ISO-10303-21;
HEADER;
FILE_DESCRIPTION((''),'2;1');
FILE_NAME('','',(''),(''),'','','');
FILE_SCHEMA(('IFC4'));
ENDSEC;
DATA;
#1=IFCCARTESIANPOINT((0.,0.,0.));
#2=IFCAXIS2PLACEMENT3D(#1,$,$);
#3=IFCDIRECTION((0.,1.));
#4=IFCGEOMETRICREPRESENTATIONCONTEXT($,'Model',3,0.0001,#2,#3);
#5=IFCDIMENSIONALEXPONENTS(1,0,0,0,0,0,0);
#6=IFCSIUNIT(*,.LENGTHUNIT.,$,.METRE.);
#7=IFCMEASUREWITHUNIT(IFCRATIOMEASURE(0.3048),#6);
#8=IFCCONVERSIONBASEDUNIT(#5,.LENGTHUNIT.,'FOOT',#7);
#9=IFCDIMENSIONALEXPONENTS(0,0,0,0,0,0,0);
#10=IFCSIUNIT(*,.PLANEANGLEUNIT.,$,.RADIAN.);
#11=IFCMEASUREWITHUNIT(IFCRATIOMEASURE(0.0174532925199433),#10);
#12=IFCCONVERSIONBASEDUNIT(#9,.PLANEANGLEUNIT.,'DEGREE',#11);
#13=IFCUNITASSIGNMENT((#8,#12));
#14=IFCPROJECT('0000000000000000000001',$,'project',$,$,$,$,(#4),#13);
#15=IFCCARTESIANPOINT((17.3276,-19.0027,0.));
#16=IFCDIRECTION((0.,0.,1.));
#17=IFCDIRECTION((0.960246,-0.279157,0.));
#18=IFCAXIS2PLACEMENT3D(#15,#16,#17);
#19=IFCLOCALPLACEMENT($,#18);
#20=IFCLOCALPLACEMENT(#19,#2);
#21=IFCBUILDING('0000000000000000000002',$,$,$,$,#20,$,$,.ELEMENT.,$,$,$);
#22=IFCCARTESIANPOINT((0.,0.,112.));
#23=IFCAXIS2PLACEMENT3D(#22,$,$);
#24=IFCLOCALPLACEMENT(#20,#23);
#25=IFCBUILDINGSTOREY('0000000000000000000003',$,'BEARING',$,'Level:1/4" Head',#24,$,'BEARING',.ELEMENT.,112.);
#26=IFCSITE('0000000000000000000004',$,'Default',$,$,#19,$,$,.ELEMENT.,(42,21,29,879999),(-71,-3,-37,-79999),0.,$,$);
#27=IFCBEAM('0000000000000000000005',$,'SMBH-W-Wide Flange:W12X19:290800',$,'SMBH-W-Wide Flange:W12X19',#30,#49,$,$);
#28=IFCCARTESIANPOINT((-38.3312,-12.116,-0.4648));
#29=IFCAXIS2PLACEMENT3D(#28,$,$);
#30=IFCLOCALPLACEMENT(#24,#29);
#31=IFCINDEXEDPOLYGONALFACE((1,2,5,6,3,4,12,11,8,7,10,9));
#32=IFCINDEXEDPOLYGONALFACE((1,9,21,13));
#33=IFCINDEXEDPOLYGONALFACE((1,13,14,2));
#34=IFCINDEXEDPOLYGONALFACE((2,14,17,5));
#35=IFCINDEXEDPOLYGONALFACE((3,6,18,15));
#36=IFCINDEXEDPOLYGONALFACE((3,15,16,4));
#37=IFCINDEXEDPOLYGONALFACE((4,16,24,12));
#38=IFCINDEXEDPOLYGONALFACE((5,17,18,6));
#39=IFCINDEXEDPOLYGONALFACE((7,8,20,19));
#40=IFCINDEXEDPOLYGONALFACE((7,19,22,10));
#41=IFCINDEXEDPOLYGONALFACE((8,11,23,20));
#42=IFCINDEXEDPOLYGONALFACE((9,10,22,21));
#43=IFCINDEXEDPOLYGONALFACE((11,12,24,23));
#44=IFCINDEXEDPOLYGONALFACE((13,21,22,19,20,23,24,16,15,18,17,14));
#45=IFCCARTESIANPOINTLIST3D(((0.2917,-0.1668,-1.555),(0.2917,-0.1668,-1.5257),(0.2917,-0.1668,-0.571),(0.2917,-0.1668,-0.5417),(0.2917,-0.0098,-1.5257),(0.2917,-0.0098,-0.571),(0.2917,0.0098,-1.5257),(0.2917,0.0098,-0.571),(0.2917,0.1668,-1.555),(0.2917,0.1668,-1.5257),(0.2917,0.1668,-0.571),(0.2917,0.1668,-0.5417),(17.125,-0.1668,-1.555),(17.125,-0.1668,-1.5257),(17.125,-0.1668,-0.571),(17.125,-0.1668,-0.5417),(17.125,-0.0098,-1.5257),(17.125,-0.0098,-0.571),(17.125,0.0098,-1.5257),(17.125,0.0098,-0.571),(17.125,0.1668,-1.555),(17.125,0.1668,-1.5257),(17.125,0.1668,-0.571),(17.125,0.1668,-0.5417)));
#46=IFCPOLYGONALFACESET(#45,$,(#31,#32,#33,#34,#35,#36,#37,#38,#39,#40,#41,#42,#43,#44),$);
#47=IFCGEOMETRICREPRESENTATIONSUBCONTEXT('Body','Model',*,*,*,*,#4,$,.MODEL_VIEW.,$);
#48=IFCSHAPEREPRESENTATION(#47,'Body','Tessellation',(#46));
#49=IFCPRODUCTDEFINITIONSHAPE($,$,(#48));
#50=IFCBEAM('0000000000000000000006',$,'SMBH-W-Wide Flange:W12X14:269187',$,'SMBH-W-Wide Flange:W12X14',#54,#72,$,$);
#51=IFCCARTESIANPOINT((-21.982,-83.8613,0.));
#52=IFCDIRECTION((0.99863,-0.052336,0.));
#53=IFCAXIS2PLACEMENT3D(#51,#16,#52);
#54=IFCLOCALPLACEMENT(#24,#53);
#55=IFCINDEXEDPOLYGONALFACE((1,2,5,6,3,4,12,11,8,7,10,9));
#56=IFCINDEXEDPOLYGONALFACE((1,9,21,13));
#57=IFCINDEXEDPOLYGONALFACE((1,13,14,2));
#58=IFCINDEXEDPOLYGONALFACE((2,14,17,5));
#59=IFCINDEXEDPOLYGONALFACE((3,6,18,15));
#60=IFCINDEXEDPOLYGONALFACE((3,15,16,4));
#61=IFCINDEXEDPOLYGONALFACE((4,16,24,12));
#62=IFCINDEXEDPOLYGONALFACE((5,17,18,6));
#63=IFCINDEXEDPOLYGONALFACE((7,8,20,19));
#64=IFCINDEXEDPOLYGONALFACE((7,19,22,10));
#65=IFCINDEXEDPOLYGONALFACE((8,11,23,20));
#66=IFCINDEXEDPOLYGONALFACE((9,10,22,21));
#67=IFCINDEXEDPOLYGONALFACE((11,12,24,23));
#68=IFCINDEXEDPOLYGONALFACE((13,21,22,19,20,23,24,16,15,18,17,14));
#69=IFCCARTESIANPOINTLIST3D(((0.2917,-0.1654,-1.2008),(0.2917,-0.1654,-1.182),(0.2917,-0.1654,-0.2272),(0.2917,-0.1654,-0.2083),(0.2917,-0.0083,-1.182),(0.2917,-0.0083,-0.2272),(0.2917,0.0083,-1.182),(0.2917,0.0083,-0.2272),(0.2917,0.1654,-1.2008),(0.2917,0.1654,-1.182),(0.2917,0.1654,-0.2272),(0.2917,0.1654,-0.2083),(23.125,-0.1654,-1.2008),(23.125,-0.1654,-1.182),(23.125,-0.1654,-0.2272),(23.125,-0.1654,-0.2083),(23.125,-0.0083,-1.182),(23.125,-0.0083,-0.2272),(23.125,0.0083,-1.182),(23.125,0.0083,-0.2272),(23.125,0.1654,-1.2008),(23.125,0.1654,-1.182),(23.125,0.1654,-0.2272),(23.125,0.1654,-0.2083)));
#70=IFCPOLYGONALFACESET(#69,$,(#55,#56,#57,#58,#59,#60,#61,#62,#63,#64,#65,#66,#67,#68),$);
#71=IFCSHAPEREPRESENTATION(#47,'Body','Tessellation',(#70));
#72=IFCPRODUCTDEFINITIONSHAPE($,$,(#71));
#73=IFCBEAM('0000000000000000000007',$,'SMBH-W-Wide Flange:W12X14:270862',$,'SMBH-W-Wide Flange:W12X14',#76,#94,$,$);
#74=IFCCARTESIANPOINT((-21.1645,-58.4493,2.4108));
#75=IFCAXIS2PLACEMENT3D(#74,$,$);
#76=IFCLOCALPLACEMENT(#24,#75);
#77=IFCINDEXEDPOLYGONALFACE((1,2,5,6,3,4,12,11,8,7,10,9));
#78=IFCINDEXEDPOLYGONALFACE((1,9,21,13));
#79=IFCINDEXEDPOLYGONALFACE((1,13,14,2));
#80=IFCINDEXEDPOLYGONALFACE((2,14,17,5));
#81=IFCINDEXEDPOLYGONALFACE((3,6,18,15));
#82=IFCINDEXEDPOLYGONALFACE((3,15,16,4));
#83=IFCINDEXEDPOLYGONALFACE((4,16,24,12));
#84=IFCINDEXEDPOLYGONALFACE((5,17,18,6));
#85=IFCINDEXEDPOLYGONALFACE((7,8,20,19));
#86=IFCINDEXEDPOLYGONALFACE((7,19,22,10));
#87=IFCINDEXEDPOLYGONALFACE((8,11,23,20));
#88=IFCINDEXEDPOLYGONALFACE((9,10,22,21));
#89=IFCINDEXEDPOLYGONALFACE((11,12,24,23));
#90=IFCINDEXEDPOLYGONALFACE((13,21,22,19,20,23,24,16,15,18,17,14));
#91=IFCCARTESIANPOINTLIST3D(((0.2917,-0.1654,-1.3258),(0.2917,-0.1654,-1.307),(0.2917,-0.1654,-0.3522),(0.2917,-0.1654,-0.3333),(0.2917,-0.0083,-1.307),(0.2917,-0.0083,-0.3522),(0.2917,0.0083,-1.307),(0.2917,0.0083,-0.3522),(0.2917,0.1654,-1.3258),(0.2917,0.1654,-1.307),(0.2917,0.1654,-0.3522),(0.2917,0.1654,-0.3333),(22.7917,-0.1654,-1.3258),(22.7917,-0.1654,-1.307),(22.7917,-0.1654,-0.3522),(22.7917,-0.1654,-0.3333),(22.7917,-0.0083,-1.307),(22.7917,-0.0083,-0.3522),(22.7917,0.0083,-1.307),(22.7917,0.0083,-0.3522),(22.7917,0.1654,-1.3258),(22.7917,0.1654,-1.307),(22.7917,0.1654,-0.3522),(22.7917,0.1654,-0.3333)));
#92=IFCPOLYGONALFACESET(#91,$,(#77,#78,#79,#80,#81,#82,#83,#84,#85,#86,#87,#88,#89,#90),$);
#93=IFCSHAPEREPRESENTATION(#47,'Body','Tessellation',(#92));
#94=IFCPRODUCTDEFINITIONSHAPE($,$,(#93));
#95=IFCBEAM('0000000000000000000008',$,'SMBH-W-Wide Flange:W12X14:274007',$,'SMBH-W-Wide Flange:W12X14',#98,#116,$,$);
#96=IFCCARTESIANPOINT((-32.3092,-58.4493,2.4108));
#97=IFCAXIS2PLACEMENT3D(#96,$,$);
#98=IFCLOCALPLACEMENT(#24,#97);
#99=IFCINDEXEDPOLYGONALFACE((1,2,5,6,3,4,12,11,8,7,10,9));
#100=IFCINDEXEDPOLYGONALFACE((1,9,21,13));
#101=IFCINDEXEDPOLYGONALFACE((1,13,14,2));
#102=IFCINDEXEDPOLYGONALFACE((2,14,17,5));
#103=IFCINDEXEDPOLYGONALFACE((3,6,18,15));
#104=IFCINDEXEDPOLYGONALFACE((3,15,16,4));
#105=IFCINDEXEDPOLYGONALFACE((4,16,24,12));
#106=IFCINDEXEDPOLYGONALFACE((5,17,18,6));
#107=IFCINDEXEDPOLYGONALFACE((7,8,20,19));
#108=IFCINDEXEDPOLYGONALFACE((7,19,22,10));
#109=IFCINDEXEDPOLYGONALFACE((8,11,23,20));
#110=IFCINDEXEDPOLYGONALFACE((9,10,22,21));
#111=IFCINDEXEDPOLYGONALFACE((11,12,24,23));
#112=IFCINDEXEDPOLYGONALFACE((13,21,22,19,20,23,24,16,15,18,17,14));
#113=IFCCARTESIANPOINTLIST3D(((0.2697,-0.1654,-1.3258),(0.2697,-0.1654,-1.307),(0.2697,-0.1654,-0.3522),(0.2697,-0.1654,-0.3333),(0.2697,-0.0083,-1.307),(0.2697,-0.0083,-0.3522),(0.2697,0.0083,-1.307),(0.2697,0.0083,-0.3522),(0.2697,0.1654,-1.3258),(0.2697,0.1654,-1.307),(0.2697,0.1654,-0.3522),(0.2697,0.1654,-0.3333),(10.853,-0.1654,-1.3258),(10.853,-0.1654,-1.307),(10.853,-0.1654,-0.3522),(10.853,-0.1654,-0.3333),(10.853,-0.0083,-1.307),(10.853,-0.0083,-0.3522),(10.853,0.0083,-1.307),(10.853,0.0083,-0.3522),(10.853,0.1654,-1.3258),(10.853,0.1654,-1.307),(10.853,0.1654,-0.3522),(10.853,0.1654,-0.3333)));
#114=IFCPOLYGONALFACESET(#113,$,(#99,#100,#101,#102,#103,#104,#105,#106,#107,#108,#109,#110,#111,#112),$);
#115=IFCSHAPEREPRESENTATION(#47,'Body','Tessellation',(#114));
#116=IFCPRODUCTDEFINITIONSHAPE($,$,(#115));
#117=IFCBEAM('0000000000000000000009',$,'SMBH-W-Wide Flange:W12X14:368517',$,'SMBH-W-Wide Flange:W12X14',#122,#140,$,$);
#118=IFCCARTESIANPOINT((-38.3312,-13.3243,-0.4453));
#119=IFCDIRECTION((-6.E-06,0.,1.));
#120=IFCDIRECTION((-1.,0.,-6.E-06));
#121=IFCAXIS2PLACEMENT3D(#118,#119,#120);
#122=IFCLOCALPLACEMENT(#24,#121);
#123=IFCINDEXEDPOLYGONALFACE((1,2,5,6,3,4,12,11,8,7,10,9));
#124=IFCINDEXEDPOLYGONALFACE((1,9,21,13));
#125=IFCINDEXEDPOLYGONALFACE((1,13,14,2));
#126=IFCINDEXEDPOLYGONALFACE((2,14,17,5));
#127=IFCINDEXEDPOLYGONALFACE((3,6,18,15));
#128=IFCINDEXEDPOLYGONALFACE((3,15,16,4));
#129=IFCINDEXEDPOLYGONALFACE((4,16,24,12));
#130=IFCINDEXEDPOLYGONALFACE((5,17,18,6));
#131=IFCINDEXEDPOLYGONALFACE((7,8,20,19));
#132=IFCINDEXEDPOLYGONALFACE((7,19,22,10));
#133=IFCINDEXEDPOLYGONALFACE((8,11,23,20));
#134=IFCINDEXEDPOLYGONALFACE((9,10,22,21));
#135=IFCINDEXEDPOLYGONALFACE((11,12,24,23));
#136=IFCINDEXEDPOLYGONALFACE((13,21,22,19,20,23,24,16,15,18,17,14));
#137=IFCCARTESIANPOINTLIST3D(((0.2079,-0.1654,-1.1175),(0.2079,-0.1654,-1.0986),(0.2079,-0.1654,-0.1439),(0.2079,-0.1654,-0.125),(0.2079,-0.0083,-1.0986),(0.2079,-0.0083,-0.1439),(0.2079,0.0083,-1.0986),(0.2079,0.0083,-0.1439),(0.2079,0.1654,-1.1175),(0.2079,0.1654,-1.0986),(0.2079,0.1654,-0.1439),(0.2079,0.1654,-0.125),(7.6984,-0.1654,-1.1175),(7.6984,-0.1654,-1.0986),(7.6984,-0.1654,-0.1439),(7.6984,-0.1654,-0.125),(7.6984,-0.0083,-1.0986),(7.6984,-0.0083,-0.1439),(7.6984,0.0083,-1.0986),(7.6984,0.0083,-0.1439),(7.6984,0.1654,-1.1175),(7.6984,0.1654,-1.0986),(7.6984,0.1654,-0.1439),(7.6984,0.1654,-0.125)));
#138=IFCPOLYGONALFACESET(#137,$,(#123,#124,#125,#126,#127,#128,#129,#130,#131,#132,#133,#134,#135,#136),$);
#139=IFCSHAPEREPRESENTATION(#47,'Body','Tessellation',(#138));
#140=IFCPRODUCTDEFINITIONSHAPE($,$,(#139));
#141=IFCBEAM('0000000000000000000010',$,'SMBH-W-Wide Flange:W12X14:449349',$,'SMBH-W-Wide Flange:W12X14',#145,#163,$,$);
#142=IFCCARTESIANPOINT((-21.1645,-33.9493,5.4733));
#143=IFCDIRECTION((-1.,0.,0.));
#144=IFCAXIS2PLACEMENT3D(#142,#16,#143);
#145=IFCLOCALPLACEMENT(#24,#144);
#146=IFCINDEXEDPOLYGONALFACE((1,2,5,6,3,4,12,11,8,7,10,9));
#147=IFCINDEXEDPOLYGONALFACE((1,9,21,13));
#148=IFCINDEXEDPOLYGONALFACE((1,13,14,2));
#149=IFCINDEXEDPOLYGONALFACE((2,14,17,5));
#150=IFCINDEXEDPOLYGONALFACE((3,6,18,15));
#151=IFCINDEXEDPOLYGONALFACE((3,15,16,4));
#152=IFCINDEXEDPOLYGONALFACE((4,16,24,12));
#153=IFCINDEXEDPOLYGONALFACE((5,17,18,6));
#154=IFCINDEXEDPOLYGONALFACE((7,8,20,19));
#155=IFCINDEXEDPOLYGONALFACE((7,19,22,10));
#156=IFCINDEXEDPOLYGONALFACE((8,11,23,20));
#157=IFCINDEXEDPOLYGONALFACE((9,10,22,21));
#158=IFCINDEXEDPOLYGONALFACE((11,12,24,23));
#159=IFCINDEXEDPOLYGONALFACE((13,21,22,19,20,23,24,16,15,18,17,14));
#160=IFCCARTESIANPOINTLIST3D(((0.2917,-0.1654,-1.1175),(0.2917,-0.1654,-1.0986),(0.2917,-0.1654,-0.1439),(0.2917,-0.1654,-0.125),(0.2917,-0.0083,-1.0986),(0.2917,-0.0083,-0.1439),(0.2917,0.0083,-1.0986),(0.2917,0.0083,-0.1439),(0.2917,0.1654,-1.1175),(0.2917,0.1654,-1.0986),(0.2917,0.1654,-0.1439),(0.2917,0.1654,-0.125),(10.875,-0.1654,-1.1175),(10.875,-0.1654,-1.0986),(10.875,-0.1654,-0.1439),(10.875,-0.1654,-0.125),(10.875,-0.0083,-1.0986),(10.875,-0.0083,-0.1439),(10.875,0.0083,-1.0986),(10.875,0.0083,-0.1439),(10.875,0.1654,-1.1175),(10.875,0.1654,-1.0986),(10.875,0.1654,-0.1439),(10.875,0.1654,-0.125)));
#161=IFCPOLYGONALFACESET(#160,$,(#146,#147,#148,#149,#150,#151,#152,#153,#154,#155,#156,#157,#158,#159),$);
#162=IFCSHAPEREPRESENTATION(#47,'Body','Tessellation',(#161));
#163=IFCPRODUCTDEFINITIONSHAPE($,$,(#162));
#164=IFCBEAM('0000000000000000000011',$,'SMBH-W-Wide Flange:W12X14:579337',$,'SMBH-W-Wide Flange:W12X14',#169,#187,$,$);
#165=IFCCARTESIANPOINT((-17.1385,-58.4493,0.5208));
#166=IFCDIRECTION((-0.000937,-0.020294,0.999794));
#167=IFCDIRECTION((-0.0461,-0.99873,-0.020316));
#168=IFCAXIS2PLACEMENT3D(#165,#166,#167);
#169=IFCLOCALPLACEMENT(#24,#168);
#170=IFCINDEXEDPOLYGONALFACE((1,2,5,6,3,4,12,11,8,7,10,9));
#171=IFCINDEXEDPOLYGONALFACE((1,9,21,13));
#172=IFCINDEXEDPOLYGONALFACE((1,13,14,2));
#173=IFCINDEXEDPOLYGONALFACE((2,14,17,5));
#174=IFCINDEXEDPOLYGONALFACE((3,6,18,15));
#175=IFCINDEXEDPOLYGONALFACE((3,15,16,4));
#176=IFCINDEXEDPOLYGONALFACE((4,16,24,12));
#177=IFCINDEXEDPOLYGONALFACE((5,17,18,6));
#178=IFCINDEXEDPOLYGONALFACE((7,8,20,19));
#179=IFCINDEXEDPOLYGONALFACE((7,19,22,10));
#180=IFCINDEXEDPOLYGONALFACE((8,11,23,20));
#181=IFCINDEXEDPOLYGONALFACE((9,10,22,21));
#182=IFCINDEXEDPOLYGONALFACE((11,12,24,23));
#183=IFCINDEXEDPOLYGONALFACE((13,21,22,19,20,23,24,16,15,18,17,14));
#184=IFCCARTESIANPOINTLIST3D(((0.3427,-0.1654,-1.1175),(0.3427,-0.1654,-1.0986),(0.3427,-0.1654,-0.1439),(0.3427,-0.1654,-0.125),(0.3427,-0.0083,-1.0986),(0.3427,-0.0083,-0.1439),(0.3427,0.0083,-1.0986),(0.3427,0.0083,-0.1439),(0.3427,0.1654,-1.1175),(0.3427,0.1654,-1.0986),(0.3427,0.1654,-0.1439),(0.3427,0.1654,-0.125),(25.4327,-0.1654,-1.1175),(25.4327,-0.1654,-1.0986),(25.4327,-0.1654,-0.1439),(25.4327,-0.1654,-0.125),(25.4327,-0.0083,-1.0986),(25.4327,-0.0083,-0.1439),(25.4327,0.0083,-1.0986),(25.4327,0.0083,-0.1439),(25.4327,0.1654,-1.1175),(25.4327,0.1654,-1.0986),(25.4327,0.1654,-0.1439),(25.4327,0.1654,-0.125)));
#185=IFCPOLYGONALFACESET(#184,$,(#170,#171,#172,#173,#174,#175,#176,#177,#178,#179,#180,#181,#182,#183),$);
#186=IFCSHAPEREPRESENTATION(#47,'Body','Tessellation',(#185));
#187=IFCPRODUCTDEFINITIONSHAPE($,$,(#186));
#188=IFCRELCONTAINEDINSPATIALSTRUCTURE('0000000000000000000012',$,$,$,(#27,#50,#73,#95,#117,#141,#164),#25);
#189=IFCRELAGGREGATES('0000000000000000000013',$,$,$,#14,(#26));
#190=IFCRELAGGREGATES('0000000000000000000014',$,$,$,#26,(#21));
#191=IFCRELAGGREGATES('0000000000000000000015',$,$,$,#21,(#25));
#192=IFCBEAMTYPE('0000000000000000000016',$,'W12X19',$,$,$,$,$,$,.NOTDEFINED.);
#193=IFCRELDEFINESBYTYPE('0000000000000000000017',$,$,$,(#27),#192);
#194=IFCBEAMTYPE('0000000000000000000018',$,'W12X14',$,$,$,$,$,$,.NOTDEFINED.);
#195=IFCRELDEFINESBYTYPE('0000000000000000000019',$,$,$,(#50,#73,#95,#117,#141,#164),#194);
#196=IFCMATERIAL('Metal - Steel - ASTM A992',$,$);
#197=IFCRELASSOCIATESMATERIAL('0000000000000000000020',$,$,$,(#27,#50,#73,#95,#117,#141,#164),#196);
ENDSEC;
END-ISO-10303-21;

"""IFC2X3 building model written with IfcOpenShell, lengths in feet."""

from ifc_helpers import new_model, entity, si_unit, converted_unit, direction, frame, frame_2d, origin, place, context, subcontext, project, spatial, i_section, extrude, material, type_object, element, save


model = new_model("IFC2X3")

# Units and contexts
model_context = context("Model", 3, precision=0.0001, world=origin(), true_north=direction((0.0, 1.0)))
body_context = subcontext(model_context, "Body", "Model", "MODEL_VIEW")
ifc_project = project(units=[converted_unit("LENGTHUNIT", "FOOT", entity("IfcRatioMeasure", 0.3048), si_unit("LENGTHUNIT", "METRE"), dimensions=[1, 0, 0, 0, 0, 0, 0]), converted_unit("PLANEANGLEUNIT", "DEGREE", entity("IfcRatioMeasure", 0.0174532925199433), si_unit("PLANEANGLEUNIT", "RADIAN"), dimensions=[0, 0, 0, 0, 0, 0, 0])], contexts=[model_context])

# Site, building, storey
site_placement = place(None, frame((17.3276, -19.0027, 0.0), z_axis=(0.0, 0.0, 1.0), x_axis=(0.960246, -0.279157, 0.0)))
site = spatial("IfcSite", under=ifc_project, at=site_placement, Name="Default", CompositionType="ELEMENT", RefLatitude=(42, 21, 29, 879999), RefLongitude=(-71, -3, -37, -79999), RefElevation=0.0)
building_placement = place(site_placement, origin())
building = spatial("IfcBuilding", under=site, at=building_placement, CompositionType="ELEMENT")
storey_placement = place(building_placement, frame((0.0, 0.0, 112.0)))
storey = spatial("IfcBuildingStorey", under=building, at=storey_placement, Name="BEARING", ObjectType="Level:1/4\" Head", LongName="BEARING", CompositionType="ELEMENT", Elevation=112.0)

# Beams
ifc_material_1 = material(Name="Metal - Steel - ASTM A992")
beam_type_1 = type_object("IfcBeamType", Name="W12X19", PredefinedType="NOTDEFINED")
beam_1_placement = place(storey_placement, frame((-38.3312, -12.116, -0.4648)))
element("IfcBeam", 1, at=beam_1_placement, inside=storey, type_object=beam_type_1, material=ifc_material_1, Name="SMBH-W-Wide Flange:W12X19:290800", ObjectType="SMBH-W-Wide Flange:W12X19", context=body_context, shape_type="SweptSolid", body=[
    extrude(i_section(OverallWidth=0.3337, OverallDepth=1.0133, WebThickness=0.0195, FlangeThickness=0.0293, at=frame_2d((0.0, 0.0), x_axis=(0.0, 1.0))), frame((0.2917, 0.0, -1.0483), z_axis=(1.0, 0.0, 0.0), x_axis=(0.0, 0.0, -1.0)), (0.0, 0.0, 1.0), 16.8333),
])
beam_type_2 = type_object("IfcBeamType", Name="W12X14", PredefinedType="NOTDEFINED")
beam_2_placement = place(storey_placement, frame((-21.982, -83.8613, 0.0), z_axis=(0.0, 0.0, 1.0), x_axis=(0.99863, -0.052336, 0.0)))
element("IfcBeam", 2, at=beam_2_placement, inside=storey, type_object=beam_type_2, material=ifc_material_1, Name="SMBH-W-Wide Flange:W12X14:269187", ObjectType="SMBH-W-Wide Flange:W12X14", context=body_context, shape_type="SweptSolid", body=[
    extrude(i_section(OverallWidth=0.3307, OverallDepth=0.9925, WebThickness=0.0166, FlangeThickness=0.0189, at=frame_2d((0.0, 0.0), x_axis=(0.0, 1.0))), frame((0.2917, 0.0, -0.7046), z_axis=(1.0, 0.0, 0.0), x_axis=(0.0, 0.0, -1.0)), (0.0, 0.0, 1.0), 22.8333),
])
beam_3_placement = place(storey_placement, frame((-21.1645, -58.4493, 2.4108)))
element("IfcBeam", 3, at=beam_3_placement, inside=storey, type_object=beam_type_2, material=ifc_material_1, Name="SMBH-W-Wide Flange:W12X14:270862", ObjectType="SMBH-W-Wide Flange:W12X14", context=body_context, shape_type="SweptSolid", body=[
    extrude(i_section(OverallWidth=0.3307, OverallDepth=0.9925, WebThickness=0.0166, FlangeThickness=0.0189, at=frame_2d((0.0, 0.0), x_axis=(0.0, 1.0))), frame((0.2917, 0.0, -0.8296), z_axis=(1.0, 0.0, 0.0), x_axis=(0.0, 0.0, -1.0)), (0.0, 0.0, 1.0), 22.5),
])
beam_4_placement = place(storey_placement, frame((-32.3092, -58.4493, 2.4108)))
element("IfcBeam", 4, at=beam_4_placement, inside=storey, type_object=beam_type_2, material=ifc_material_1, Name="SMBH-W-Wide Flange:W12X14:274007", ObjectType="SMBH-W-Wide Flange:W12X14", context=body_context, shape_type="SweptSolid", body=[
    extrude(i_section(OverallWidth=0.3307, OverallDepth=0.9925, WebThickness=0.0166, FlangeThickness=0.0189, at=frame_2d((0.0, 0.0), x_axis=(0.0, 1.0))), frame((0.2697, 0.0, -0.8296), z_axis=(1.0, 0.0, 0.0), x_axis=(0.0, 0.0, -1.0)), (0.0, 0.0, 1.0), 10.5833),
])
beam_5_placement = place(storey_placement, frame((-38.3312, -13.3243, -0.4453), z_axis=(-0.000006, 0.0, 1.0), x_axis=(-1.0, 0.0, -0.000006)))
element("IfcBeam", 5, at=beam_5_placement, inside=storey, type_object=beam_type_2, material=ifc_material_1, Name="SMBH-W-Wide Flange:W12X14:368517", ObjectType="SMBH-W-Wide Flange:W12X14", context=body_context, shape_type="SweptSolid", body=[
    extrude(i_section(OverallWidth=0.3307, OverallDepth=0.9925, WebThickness=0.0166, FlangeThickness=0.0189, at=frame_2d((0.0, 0.0), x_axis=(0.0, 1.0))), frame((0.2079, 0.0, -0.6213), z_axis=(1.0, 0.0, 0.0), x_axis=(0.0, 0.0, -1.0)), (0.0, 0.0, 1.0), 7.4906),
])
beam_6_placement = place(storey_placement, frame((-21.1645, -33.9493, 5.4733), z_axis=(0.0, 0.0, 1.0), x_axis=(-1.0, 0.0, 0.0)))
element("IfcBeam", 6, at=beam_6_placement, inside=storey, type_object=beam_type_2, material=ifc_material_1, Name="SMBH-W-Wide Flange:W12X14:449349", ObjectType="SMBH-W-Wide Flange:W12X14", context=body_context, shape_type="SweptSolid", body=[
    extrude(i_section(OverallWidth=0.3307, OverallDepth=0.9925, WebThickness=0.0166, FlangeThickness=0.0189, at=frame_2d((0.0, 0.0), x_axis=(0.0, 1.0))), frame((0.2917, 0.0, -0.6213), z_axis=(1.0, 0.0, 0.0), x_axis=(0.0, 0.0, -1.0)), (0.0, 0.0, 1.0), 10.5833),
])
beam_7_placement = place(storey_placement, frame((-17.1385, -58.4493, 0.5208), z_axis=(-0.000937, -0.020294, 0.999794), x_axis=(-0.0461, -0.99873, -0.020316)))
element("IfcBeam", 7, at=beam_7_placement, inside=storey, type_object=beam_type_2, material=ifc_material_1, Name="SMBH-W-Wide Flange:W12X14:579337", ObjectType="SMBH-W-Wide Flange:W12X14", context=body_context, shape_type="SweptSolid", body=[
    extrude(i_section(OverallWidth=0.3307, OverallDepth=0.9925, WebThickness=0.0166, FlangeThickness=0.0189, at=frame_2d((0.0, 0.0), x_axis=(0.0, 1.0))), frame((0.3427, 0.0, -0.6213), z_axis=(1.0, 0.0, 0.0), x_axis=(0.0, 0.0, -1.0)), (0.0, 0.0, 1.0), 25.09),
])

save(model, "model.ifc")
